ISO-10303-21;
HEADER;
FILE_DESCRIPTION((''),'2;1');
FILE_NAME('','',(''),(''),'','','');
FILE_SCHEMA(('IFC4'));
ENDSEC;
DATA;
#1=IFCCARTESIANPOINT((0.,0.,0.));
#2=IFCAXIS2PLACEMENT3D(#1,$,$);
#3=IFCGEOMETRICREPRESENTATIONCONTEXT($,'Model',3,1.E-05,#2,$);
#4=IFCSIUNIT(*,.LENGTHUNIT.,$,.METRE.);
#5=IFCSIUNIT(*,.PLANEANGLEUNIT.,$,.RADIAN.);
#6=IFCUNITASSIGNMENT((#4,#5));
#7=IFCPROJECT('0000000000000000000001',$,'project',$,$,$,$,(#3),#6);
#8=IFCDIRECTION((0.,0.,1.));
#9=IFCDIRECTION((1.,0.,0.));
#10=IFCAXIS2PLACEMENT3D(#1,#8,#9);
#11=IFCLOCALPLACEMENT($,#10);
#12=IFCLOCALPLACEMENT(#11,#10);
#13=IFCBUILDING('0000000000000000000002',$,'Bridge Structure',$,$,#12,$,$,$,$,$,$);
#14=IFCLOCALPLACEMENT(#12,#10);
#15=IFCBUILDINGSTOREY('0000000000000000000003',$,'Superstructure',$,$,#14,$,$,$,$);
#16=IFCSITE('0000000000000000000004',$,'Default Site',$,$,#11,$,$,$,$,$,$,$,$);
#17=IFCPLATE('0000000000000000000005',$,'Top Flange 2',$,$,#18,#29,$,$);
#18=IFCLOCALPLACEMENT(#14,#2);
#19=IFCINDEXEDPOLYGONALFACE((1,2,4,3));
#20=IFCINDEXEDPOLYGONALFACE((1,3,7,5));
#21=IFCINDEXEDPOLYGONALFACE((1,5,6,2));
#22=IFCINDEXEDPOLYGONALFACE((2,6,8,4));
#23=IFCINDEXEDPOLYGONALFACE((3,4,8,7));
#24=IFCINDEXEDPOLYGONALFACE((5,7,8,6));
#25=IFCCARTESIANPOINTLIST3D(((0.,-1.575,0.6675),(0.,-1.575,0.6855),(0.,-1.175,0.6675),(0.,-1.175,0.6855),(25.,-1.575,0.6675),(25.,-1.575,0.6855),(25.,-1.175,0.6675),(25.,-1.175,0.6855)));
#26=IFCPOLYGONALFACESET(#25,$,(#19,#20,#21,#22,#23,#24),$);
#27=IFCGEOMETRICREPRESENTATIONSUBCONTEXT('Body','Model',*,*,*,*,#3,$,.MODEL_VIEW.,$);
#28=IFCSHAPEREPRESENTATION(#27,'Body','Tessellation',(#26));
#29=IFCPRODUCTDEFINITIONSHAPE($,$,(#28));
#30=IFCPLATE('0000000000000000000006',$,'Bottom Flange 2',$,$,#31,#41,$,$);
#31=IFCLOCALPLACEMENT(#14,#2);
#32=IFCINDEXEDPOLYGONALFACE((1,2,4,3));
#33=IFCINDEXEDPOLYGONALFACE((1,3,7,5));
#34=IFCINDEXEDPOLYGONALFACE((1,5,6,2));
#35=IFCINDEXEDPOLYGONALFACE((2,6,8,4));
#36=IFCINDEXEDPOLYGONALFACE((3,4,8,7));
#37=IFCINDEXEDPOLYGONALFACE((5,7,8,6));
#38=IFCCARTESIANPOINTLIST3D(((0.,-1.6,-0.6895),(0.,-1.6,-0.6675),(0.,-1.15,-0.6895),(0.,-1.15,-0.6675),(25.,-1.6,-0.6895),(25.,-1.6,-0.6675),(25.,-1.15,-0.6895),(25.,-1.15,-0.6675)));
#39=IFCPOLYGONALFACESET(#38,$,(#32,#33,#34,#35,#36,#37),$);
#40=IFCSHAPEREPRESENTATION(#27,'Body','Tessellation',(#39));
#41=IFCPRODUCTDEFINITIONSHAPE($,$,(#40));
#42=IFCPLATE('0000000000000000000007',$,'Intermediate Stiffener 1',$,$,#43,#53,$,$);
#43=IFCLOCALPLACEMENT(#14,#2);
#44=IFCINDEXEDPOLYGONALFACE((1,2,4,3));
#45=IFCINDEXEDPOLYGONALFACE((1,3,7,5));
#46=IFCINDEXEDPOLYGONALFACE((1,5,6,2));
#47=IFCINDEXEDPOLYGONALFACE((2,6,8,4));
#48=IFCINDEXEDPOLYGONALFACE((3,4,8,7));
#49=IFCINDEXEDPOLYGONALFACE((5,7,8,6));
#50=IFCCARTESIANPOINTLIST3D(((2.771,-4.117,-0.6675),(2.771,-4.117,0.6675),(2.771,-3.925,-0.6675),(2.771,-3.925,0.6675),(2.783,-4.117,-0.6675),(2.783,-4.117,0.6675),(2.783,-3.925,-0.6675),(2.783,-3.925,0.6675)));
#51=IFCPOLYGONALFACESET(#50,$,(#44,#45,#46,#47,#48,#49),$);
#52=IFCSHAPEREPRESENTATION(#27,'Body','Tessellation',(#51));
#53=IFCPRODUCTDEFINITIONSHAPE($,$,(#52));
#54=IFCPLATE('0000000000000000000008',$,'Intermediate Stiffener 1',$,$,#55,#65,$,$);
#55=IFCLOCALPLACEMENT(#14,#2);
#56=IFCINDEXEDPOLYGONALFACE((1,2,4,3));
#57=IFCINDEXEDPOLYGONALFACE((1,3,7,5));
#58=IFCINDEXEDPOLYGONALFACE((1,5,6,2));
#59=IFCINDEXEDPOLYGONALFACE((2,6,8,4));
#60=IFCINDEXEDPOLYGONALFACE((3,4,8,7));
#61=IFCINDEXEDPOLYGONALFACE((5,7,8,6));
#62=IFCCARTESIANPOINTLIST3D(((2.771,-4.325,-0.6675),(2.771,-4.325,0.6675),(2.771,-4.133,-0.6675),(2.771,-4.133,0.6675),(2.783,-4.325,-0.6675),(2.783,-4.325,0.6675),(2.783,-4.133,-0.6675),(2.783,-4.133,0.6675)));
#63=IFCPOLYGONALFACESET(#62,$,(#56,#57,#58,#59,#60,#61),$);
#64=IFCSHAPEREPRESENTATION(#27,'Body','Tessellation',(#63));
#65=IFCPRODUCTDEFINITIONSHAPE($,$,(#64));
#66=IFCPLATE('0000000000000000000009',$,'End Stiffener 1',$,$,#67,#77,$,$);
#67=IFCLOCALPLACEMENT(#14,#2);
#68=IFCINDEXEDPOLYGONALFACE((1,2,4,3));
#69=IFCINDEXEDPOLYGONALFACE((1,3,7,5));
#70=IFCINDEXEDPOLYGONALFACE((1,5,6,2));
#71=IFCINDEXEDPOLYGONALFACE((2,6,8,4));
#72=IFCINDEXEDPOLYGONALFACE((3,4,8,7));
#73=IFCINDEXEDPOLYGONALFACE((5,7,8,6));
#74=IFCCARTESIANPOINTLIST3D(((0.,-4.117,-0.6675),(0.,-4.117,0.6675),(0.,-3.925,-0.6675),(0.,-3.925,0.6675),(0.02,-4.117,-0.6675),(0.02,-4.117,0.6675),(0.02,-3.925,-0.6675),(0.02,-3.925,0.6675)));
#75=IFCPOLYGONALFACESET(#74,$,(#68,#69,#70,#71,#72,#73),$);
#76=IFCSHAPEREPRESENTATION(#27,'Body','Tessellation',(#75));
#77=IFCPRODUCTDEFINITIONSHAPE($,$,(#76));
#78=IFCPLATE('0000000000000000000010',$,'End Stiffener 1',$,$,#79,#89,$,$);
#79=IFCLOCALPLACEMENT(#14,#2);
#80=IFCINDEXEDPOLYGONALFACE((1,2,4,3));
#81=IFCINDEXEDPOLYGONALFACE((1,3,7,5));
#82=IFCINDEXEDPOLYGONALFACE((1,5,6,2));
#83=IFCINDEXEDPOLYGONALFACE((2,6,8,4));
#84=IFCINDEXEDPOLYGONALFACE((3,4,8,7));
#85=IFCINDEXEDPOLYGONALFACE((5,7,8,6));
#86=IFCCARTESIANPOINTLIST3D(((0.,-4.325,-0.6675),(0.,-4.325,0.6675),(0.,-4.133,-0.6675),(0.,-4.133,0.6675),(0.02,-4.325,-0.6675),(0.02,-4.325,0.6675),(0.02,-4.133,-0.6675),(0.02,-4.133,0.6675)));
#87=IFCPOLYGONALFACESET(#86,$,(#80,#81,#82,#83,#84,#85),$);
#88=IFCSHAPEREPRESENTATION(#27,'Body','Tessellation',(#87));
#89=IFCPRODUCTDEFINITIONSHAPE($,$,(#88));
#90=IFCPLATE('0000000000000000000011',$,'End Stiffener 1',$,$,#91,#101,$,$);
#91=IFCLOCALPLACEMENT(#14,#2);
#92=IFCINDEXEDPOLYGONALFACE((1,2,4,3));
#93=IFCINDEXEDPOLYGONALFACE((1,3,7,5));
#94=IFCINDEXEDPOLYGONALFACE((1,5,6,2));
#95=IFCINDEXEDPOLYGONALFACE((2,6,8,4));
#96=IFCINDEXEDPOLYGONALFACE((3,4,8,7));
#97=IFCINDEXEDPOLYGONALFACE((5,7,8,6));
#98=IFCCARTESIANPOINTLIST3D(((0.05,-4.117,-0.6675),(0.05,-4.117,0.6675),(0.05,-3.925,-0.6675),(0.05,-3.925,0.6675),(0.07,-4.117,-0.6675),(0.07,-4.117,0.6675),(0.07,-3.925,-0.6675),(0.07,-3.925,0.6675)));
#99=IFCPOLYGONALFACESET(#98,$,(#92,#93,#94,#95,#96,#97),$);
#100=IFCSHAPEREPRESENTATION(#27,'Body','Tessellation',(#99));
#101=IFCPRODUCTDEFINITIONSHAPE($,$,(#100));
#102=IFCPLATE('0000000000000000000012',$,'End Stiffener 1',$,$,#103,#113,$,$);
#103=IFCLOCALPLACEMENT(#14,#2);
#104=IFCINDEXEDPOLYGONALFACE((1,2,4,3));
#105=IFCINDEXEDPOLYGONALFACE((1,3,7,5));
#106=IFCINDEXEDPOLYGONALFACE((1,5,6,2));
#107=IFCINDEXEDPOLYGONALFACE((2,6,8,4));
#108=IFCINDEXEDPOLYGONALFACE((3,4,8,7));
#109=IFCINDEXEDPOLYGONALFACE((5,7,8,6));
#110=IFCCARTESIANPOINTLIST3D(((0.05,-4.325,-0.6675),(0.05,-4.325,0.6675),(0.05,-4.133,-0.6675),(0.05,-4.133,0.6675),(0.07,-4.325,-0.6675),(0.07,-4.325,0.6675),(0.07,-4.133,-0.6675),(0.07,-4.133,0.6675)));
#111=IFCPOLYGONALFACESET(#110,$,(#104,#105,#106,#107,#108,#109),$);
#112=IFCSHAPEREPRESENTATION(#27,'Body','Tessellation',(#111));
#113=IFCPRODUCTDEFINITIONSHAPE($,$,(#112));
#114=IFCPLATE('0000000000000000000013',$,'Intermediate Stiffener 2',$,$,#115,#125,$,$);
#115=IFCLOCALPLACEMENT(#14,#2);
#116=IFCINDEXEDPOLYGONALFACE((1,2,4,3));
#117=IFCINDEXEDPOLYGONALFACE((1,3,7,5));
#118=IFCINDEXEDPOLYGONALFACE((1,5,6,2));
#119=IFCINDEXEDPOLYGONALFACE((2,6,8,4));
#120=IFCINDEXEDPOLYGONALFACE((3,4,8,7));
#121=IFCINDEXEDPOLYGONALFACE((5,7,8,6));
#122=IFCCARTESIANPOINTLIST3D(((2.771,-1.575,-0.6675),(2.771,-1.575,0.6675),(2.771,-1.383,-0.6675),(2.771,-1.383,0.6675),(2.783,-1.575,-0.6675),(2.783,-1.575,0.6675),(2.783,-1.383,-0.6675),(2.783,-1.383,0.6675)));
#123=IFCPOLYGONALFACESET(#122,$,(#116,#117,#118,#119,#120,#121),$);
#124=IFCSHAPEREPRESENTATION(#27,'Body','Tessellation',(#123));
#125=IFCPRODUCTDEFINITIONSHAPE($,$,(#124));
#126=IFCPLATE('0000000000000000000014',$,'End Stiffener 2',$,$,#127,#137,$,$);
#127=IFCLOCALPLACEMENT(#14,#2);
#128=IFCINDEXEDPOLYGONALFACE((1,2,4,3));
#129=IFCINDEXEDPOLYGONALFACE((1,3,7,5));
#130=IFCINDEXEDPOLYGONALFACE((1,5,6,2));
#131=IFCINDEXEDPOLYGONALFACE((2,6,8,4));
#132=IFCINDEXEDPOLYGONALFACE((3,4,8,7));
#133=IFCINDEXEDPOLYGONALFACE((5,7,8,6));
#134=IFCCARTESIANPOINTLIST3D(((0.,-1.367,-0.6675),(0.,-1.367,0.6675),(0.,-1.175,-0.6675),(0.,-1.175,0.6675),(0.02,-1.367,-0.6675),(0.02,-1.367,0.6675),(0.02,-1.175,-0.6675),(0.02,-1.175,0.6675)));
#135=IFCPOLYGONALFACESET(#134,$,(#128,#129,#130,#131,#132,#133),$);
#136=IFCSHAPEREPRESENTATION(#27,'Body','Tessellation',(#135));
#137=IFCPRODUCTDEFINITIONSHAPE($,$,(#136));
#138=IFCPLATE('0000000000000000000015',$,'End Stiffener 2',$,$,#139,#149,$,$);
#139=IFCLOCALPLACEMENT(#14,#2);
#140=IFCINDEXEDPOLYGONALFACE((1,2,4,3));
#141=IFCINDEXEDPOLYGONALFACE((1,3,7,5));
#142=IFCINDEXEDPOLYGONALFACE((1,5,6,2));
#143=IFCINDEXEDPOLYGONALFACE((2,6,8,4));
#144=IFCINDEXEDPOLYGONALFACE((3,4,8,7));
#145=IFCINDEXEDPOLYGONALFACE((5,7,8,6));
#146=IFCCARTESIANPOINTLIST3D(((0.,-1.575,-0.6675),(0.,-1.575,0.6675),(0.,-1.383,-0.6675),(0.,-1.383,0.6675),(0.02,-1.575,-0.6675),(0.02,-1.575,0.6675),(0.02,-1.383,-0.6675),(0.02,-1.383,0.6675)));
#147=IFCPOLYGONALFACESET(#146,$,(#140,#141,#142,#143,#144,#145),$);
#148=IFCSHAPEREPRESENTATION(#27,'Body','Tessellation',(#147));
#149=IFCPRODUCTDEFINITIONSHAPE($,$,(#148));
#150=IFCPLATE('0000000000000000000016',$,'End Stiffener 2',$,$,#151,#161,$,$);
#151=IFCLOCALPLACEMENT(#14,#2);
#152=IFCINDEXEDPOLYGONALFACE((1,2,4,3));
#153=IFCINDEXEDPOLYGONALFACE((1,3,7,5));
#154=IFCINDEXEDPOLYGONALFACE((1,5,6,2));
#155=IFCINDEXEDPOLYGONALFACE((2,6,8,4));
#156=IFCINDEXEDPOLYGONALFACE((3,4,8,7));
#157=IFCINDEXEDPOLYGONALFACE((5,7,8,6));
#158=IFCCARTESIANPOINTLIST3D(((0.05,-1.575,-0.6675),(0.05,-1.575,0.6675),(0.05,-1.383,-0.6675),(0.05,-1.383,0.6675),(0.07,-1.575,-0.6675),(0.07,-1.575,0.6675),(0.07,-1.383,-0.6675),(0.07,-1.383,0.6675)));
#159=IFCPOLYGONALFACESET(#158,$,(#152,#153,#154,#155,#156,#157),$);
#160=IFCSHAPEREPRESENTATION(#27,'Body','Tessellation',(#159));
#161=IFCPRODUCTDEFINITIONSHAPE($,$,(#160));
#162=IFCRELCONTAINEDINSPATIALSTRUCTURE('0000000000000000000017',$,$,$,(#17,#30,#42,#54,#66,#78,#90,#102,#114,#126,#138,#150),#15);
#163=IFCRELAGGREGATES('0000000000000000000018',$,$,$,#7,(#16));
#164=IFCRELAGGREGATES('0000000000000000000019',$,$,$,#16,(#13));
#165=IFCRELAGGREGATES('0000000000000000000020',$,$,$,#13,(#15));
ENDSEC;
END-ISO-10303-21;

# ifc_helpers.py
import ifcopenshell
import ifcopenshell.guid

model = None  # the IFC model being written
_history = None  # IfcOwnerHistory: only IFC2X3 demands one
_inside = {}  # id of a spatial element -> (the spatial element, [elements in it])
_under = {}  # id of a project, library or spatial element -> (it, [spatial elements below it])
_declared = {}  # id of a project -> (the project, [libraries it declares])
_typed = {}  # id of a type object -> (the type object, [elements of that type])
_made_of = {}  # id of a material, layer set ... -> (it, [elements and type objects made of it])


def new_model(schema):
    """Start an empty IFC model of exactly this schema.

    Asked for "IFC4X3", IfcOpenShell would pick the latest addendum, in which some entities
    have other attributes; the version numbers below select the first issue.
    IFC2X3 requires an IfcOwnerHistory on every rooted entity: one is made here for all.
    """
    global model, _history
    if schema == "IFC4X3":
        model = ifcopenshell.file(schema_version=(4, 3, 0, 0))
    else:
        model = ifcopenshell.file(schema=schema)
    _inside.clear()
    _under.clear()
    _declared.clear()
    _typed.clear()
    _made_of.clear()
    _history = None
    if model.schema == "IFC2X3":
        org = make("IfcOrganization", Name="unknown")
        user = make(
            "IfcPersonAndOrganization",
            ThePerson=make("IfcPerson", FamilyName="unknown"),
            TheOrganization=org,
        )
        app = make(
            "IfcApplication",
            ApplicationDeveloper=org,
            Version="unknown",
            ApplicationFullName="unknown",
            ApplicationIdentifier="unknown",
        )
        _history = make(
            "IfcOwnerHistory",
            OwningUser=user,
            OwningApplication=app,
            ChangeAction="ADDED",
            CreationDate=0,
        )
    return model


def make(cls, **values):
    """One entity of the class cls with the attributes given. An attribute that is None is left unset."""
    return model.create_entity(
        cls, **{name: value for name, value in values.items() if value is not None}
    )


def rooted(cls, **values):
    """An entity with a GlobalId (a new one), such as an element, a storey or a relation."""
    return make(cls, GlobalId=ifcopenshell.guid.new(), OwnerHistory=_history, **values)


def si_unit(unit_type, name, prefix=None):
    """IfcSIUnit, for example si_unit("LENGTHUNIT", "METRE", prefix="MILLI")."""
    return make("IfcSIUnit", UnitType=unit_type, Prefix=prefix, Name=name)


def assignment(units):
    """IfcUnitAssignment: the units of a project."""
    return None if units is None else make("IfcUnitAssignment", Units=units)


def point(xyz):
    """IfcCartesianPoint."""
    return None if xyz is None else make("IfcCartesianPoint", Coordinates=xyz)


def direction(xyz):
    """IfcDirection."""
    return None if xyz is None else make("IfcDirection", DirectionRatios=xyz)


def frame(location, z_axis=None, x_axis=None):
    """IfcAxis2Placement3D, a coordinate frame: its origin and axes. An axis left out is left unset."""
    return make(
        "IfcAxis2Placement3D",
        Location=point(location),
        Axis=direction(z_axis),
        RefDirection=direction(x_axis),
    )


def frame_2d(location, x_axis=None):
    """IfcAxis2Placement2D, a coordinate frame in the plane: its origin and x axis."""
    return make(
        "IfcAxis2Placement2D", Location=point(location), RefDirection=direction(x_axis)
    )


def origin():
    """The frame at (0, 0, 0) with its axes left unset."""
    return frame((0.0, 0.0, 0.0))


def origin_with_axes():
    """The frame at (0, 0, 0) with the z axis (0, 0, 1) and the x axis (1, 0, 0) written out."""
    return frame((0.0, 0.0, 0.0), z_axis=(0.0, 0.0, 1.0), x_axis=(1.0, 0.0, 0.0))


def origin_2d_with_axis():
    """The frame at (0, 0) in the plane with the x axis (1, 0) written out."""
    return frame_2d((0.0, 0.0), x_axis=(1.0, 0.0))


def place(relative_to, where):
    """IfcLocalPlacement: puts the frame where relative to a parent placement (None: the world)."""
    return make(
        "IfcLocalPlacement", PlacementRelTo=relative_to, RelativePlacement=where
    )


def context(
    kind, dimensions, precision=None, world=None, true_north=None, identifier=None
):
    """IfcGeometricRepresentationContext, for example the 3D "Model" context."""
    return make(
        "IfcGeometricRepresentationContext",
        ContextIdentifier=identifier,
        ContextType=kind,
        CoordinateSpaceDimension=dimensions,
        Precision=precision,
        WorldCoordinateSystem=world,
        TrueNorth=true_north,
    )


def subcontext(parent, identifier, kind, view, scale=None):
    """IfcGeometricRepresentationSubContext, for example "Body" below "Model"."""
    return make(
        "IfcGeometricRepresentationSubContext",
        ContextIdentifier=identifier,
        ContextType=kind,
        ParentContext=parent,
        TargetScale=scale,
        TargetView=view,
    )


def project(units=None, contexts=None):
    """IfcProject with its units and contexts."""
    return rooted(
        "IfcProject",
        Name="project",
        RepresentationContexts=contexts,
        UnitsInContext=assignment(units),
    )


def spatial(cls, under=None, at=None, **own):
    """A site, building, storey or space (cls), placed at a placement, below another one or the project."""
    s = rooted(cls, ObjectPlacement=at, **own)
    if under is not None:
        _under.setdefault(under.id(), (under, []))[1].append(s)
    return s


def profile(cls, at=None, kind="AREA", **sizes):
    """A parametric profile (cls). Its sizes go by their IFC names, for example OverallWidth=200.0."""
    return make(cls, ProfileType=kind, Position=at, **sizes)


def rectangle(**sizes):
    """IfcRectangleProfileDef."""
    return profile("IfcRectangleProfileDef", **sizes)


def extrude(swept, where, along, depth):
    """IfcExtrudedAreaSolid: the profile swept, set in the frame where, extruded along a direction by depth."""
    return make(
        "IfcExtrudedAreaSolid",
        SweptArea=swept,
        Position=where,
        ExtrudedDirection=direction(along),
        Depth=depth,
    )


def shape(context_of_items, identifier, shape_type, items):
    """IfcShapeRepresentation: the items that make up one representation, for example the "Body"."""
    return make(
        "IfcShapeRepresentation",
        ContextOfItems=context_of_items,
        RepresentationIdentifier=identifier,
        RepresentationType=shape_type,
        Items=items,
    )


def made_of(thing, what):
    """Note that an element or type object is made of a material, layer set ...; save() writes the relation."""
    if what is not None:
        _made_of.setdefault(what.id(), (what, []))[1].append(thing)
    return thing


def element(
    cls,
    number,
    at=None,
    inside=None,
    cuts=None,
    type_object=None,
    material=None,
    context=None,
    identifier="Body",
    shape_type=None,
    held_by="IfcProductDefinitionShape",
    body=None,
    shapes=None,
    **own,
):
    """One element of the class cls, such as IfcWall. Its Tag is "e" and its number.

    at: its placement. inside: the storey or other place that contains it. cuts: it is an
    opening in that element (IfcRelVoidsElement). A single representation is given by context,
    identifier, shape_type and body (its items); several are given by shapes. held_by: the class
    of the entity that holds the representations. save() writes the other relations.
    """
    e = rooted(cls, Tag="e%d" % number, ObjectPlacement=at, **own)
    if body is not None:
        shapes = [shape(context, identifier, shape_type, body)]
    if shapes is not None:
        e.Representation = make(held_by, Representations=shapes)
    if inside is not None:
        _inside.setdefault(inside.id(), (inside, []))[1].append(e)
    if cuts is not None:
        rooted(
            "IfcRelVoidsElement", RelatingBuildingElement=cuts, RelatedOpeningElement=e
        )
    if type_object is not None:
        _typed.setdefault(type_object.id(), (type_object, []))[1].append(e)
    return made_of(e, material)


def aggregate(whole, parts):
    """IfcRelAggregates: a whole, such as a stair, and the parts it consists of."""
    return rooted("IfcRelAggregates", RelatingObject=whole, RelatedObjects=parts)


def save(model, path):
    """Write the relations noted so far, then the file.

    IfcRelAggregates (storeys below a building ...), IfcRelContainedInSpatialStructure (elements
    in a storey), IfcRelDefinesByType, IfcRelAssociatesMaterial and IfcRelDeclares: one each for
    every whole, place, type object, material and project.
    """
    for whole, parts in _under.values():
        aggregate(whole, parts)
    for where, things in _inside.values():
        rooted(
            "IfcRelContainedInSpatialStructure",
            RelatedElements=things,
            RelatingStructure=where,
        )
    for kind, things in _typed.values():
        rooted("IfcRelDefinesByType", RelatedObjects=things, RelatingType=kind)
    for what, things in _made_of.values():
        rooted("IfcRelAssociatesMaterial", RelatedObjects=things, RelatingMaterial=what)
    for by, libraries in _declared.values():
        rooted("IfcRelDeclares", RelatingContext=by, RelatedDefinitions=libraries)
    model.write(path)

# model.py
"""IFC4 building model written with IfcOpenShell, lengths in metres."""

from ifc_helpers import new_model, si_unit, frame, origin, origin_with_axes, origin_2d_with_axis, place, context, subcontext, project, spatial, rectangle, extrude, element, save


model = new_model("IFC4")

# Units and contexts
model_context = context("Model", 3, precision=1e-05, world=origin())
body_context = subcontext(model_context, "Body", "Model", "MODEL_VIEW")
ifc_project = project(units=[si_unit("LENGTHUNIT", "METRE"), si_unit("PLANEANGLEUNIT", "RADIAN")], contexts=[model_context])

# Site, building, storey
site_placement = place(None, origin_with_axes())
site = spatial("IfcSite", under=ifc_project, at=site_placement, Name="Default Site")
building_placement = place(site_placement, origin_with_axes())
building = spatial("IfcBuilding", under=site, at=building_placement, Name="Bridge Structure")
storey_placement = place(building_placement, origin_with_axes())
storey = spatial("IfcBuildingStorey", under=building, at=storey_placement, Name="Superstructure")

# Plates
plate_1_placement = place(storey_placement, frame((0.0, -1.375, 0.6765), z_axis=(1.0, 0.0, 0.0), x_axis=(0.0, 1.0, 0.0)))
element("IfcPlate", 1, at=plate_1_placement, inside=storey, Name="Top Flange 2", context=body_context, shape_type="SweptSolid", body=[
    extrude(rectangle(XDim=0.4, YDim=0.018, at=origin_2d_with_axis()), origin_with_axes(), (0.0, 0.0, 1.0), 25.0),
])
plate_2_placement = place(storey_placement, frame((0.0, -1.375, -0.6785), z_axis=(1.0, 0.0, 0.0), x_axis=(0.0, 1.0, 0.0)))
element("IfcPlate", 2, at=plate_2_placement, inside=storey, Name="Bottom Flange 2", context=body_context, shape_type="SweptSolid", body=[
    extrude(rectangle(XDim=0.45, YDim=0.022, at=origin_2d_with_axis()), origin_with_axes(), (0.0, 0.0, 1.0), 25.0),
])
for number, where, z_axis, x_axis, name in (
    (3, (2.777, -4.021, -0.6675), (0.0, 0.0, 1.0), (1.0, 0.0, 0.0), "Intermediate Stiffener 1"),
    (4, (2.777, -4.229, -0.6675), (0.0, 0.0, 1.0), (1.0, 0.0, 0.0), "Intermediate Stiffener 1"),
):
    element("IfcPlate", number, at=place(storey_placement, frame(where, z_axis=z_axis, x_axis=x_axis)), inside=storey, Name=name, context=body_context, shape_type="SweptSolid", body=[
        extrude(rectangle(XDim=0.012, YDim=0.192, at=origin_2d_with_axis()), origin_with_axes(), (0.0, 0.0, 1.0), 1.335),
    ])
for number, where, z_axis, x_axis, name in (
    (5, (0.01, -4.021, -0.6675), (0.0, 0.0, 1.0), (1.0, 0.0, 0.0), "End Stiffener 1"),
    (6, (0.01, -4.229, -0.6675), (0.0, 0.0, 1.0), (1.0, 0.0, 0.0), "End Stiffener 1"),
    (7, (0.06, -4.021, -0.6675), (0.0, 0.0, 1.0), (1.0, 0.0, 0.0), "End Stiffener 1"),
    (8, (0.06, -4.229, -0.6675), (0.0, 0.0, 1.0), (1.0, 0.0, 0.0), "End Stiffener 1"),
):
    element("IfcPlate", number, at=place(storey_placement, frame(where, z_axis=z_axis, x_axis=x_axis)), inside=storey, Name=name, context=body_context, shape_type="SweptSolid", body=[
        extrude(rectangle(XDim=0.02, YDim=0.192, at=origin_2d_with_axis()), origin_with_axes(), (0.0, 0.0, 1.0), 1.335),
    ])
plate_3_placement = place(storey_placement, frame((2.777, -1.479, -0.6675), z_axis=(0.0, 0.0, 1.0), x_axis=(1.0, 0.0, 0.0)))
element("IfcPlate", 9, at=plate_3_placement, inside=storey, Name="Intermediate Stiffener 2", context=body_context, shape_type="SweptSolid", body=[
    extrude(rectangle(XDim=0.012, YDim=0.192, at=origin_2d_with_axis()), origin_with_axes(), (0.0, 0.0, 1.0), 1.335),
])
for number, where, z_axis, x_axis, name in (
    (10, (0.01, -1.271, -0.6675), (0.0, 0.0, 1.0), (1.0, 0.0, 0.0), "End Stiffener 2"),
    (11, (0.01, -1.479, -0.6675), (0.0, 0.0, 1.0), (1.0, 0.0, 0.0), "End Stiffener 2"),
    (12, (0.06, -1.479, -0.6675), (0.0, 0.0, 1.0), (1.0, 0.0, 0.0), "End Stiffener 2"),
):
    element("IfcPlate", number, at=place(storey_placement, frame(where, z_axis=z_axis, x_axis=x_axis)), inside=storey, Name=name, context=body_context, shape_type="SweptSolid", body=[
        extrude(rectangle(XDim=0.02, YDim=0.192, at=origin_2d_with_axis()), origin_with_axes(), (0.0, 0.0, 1.0), 1.335),
    ])

save(model, "model.ifc")
